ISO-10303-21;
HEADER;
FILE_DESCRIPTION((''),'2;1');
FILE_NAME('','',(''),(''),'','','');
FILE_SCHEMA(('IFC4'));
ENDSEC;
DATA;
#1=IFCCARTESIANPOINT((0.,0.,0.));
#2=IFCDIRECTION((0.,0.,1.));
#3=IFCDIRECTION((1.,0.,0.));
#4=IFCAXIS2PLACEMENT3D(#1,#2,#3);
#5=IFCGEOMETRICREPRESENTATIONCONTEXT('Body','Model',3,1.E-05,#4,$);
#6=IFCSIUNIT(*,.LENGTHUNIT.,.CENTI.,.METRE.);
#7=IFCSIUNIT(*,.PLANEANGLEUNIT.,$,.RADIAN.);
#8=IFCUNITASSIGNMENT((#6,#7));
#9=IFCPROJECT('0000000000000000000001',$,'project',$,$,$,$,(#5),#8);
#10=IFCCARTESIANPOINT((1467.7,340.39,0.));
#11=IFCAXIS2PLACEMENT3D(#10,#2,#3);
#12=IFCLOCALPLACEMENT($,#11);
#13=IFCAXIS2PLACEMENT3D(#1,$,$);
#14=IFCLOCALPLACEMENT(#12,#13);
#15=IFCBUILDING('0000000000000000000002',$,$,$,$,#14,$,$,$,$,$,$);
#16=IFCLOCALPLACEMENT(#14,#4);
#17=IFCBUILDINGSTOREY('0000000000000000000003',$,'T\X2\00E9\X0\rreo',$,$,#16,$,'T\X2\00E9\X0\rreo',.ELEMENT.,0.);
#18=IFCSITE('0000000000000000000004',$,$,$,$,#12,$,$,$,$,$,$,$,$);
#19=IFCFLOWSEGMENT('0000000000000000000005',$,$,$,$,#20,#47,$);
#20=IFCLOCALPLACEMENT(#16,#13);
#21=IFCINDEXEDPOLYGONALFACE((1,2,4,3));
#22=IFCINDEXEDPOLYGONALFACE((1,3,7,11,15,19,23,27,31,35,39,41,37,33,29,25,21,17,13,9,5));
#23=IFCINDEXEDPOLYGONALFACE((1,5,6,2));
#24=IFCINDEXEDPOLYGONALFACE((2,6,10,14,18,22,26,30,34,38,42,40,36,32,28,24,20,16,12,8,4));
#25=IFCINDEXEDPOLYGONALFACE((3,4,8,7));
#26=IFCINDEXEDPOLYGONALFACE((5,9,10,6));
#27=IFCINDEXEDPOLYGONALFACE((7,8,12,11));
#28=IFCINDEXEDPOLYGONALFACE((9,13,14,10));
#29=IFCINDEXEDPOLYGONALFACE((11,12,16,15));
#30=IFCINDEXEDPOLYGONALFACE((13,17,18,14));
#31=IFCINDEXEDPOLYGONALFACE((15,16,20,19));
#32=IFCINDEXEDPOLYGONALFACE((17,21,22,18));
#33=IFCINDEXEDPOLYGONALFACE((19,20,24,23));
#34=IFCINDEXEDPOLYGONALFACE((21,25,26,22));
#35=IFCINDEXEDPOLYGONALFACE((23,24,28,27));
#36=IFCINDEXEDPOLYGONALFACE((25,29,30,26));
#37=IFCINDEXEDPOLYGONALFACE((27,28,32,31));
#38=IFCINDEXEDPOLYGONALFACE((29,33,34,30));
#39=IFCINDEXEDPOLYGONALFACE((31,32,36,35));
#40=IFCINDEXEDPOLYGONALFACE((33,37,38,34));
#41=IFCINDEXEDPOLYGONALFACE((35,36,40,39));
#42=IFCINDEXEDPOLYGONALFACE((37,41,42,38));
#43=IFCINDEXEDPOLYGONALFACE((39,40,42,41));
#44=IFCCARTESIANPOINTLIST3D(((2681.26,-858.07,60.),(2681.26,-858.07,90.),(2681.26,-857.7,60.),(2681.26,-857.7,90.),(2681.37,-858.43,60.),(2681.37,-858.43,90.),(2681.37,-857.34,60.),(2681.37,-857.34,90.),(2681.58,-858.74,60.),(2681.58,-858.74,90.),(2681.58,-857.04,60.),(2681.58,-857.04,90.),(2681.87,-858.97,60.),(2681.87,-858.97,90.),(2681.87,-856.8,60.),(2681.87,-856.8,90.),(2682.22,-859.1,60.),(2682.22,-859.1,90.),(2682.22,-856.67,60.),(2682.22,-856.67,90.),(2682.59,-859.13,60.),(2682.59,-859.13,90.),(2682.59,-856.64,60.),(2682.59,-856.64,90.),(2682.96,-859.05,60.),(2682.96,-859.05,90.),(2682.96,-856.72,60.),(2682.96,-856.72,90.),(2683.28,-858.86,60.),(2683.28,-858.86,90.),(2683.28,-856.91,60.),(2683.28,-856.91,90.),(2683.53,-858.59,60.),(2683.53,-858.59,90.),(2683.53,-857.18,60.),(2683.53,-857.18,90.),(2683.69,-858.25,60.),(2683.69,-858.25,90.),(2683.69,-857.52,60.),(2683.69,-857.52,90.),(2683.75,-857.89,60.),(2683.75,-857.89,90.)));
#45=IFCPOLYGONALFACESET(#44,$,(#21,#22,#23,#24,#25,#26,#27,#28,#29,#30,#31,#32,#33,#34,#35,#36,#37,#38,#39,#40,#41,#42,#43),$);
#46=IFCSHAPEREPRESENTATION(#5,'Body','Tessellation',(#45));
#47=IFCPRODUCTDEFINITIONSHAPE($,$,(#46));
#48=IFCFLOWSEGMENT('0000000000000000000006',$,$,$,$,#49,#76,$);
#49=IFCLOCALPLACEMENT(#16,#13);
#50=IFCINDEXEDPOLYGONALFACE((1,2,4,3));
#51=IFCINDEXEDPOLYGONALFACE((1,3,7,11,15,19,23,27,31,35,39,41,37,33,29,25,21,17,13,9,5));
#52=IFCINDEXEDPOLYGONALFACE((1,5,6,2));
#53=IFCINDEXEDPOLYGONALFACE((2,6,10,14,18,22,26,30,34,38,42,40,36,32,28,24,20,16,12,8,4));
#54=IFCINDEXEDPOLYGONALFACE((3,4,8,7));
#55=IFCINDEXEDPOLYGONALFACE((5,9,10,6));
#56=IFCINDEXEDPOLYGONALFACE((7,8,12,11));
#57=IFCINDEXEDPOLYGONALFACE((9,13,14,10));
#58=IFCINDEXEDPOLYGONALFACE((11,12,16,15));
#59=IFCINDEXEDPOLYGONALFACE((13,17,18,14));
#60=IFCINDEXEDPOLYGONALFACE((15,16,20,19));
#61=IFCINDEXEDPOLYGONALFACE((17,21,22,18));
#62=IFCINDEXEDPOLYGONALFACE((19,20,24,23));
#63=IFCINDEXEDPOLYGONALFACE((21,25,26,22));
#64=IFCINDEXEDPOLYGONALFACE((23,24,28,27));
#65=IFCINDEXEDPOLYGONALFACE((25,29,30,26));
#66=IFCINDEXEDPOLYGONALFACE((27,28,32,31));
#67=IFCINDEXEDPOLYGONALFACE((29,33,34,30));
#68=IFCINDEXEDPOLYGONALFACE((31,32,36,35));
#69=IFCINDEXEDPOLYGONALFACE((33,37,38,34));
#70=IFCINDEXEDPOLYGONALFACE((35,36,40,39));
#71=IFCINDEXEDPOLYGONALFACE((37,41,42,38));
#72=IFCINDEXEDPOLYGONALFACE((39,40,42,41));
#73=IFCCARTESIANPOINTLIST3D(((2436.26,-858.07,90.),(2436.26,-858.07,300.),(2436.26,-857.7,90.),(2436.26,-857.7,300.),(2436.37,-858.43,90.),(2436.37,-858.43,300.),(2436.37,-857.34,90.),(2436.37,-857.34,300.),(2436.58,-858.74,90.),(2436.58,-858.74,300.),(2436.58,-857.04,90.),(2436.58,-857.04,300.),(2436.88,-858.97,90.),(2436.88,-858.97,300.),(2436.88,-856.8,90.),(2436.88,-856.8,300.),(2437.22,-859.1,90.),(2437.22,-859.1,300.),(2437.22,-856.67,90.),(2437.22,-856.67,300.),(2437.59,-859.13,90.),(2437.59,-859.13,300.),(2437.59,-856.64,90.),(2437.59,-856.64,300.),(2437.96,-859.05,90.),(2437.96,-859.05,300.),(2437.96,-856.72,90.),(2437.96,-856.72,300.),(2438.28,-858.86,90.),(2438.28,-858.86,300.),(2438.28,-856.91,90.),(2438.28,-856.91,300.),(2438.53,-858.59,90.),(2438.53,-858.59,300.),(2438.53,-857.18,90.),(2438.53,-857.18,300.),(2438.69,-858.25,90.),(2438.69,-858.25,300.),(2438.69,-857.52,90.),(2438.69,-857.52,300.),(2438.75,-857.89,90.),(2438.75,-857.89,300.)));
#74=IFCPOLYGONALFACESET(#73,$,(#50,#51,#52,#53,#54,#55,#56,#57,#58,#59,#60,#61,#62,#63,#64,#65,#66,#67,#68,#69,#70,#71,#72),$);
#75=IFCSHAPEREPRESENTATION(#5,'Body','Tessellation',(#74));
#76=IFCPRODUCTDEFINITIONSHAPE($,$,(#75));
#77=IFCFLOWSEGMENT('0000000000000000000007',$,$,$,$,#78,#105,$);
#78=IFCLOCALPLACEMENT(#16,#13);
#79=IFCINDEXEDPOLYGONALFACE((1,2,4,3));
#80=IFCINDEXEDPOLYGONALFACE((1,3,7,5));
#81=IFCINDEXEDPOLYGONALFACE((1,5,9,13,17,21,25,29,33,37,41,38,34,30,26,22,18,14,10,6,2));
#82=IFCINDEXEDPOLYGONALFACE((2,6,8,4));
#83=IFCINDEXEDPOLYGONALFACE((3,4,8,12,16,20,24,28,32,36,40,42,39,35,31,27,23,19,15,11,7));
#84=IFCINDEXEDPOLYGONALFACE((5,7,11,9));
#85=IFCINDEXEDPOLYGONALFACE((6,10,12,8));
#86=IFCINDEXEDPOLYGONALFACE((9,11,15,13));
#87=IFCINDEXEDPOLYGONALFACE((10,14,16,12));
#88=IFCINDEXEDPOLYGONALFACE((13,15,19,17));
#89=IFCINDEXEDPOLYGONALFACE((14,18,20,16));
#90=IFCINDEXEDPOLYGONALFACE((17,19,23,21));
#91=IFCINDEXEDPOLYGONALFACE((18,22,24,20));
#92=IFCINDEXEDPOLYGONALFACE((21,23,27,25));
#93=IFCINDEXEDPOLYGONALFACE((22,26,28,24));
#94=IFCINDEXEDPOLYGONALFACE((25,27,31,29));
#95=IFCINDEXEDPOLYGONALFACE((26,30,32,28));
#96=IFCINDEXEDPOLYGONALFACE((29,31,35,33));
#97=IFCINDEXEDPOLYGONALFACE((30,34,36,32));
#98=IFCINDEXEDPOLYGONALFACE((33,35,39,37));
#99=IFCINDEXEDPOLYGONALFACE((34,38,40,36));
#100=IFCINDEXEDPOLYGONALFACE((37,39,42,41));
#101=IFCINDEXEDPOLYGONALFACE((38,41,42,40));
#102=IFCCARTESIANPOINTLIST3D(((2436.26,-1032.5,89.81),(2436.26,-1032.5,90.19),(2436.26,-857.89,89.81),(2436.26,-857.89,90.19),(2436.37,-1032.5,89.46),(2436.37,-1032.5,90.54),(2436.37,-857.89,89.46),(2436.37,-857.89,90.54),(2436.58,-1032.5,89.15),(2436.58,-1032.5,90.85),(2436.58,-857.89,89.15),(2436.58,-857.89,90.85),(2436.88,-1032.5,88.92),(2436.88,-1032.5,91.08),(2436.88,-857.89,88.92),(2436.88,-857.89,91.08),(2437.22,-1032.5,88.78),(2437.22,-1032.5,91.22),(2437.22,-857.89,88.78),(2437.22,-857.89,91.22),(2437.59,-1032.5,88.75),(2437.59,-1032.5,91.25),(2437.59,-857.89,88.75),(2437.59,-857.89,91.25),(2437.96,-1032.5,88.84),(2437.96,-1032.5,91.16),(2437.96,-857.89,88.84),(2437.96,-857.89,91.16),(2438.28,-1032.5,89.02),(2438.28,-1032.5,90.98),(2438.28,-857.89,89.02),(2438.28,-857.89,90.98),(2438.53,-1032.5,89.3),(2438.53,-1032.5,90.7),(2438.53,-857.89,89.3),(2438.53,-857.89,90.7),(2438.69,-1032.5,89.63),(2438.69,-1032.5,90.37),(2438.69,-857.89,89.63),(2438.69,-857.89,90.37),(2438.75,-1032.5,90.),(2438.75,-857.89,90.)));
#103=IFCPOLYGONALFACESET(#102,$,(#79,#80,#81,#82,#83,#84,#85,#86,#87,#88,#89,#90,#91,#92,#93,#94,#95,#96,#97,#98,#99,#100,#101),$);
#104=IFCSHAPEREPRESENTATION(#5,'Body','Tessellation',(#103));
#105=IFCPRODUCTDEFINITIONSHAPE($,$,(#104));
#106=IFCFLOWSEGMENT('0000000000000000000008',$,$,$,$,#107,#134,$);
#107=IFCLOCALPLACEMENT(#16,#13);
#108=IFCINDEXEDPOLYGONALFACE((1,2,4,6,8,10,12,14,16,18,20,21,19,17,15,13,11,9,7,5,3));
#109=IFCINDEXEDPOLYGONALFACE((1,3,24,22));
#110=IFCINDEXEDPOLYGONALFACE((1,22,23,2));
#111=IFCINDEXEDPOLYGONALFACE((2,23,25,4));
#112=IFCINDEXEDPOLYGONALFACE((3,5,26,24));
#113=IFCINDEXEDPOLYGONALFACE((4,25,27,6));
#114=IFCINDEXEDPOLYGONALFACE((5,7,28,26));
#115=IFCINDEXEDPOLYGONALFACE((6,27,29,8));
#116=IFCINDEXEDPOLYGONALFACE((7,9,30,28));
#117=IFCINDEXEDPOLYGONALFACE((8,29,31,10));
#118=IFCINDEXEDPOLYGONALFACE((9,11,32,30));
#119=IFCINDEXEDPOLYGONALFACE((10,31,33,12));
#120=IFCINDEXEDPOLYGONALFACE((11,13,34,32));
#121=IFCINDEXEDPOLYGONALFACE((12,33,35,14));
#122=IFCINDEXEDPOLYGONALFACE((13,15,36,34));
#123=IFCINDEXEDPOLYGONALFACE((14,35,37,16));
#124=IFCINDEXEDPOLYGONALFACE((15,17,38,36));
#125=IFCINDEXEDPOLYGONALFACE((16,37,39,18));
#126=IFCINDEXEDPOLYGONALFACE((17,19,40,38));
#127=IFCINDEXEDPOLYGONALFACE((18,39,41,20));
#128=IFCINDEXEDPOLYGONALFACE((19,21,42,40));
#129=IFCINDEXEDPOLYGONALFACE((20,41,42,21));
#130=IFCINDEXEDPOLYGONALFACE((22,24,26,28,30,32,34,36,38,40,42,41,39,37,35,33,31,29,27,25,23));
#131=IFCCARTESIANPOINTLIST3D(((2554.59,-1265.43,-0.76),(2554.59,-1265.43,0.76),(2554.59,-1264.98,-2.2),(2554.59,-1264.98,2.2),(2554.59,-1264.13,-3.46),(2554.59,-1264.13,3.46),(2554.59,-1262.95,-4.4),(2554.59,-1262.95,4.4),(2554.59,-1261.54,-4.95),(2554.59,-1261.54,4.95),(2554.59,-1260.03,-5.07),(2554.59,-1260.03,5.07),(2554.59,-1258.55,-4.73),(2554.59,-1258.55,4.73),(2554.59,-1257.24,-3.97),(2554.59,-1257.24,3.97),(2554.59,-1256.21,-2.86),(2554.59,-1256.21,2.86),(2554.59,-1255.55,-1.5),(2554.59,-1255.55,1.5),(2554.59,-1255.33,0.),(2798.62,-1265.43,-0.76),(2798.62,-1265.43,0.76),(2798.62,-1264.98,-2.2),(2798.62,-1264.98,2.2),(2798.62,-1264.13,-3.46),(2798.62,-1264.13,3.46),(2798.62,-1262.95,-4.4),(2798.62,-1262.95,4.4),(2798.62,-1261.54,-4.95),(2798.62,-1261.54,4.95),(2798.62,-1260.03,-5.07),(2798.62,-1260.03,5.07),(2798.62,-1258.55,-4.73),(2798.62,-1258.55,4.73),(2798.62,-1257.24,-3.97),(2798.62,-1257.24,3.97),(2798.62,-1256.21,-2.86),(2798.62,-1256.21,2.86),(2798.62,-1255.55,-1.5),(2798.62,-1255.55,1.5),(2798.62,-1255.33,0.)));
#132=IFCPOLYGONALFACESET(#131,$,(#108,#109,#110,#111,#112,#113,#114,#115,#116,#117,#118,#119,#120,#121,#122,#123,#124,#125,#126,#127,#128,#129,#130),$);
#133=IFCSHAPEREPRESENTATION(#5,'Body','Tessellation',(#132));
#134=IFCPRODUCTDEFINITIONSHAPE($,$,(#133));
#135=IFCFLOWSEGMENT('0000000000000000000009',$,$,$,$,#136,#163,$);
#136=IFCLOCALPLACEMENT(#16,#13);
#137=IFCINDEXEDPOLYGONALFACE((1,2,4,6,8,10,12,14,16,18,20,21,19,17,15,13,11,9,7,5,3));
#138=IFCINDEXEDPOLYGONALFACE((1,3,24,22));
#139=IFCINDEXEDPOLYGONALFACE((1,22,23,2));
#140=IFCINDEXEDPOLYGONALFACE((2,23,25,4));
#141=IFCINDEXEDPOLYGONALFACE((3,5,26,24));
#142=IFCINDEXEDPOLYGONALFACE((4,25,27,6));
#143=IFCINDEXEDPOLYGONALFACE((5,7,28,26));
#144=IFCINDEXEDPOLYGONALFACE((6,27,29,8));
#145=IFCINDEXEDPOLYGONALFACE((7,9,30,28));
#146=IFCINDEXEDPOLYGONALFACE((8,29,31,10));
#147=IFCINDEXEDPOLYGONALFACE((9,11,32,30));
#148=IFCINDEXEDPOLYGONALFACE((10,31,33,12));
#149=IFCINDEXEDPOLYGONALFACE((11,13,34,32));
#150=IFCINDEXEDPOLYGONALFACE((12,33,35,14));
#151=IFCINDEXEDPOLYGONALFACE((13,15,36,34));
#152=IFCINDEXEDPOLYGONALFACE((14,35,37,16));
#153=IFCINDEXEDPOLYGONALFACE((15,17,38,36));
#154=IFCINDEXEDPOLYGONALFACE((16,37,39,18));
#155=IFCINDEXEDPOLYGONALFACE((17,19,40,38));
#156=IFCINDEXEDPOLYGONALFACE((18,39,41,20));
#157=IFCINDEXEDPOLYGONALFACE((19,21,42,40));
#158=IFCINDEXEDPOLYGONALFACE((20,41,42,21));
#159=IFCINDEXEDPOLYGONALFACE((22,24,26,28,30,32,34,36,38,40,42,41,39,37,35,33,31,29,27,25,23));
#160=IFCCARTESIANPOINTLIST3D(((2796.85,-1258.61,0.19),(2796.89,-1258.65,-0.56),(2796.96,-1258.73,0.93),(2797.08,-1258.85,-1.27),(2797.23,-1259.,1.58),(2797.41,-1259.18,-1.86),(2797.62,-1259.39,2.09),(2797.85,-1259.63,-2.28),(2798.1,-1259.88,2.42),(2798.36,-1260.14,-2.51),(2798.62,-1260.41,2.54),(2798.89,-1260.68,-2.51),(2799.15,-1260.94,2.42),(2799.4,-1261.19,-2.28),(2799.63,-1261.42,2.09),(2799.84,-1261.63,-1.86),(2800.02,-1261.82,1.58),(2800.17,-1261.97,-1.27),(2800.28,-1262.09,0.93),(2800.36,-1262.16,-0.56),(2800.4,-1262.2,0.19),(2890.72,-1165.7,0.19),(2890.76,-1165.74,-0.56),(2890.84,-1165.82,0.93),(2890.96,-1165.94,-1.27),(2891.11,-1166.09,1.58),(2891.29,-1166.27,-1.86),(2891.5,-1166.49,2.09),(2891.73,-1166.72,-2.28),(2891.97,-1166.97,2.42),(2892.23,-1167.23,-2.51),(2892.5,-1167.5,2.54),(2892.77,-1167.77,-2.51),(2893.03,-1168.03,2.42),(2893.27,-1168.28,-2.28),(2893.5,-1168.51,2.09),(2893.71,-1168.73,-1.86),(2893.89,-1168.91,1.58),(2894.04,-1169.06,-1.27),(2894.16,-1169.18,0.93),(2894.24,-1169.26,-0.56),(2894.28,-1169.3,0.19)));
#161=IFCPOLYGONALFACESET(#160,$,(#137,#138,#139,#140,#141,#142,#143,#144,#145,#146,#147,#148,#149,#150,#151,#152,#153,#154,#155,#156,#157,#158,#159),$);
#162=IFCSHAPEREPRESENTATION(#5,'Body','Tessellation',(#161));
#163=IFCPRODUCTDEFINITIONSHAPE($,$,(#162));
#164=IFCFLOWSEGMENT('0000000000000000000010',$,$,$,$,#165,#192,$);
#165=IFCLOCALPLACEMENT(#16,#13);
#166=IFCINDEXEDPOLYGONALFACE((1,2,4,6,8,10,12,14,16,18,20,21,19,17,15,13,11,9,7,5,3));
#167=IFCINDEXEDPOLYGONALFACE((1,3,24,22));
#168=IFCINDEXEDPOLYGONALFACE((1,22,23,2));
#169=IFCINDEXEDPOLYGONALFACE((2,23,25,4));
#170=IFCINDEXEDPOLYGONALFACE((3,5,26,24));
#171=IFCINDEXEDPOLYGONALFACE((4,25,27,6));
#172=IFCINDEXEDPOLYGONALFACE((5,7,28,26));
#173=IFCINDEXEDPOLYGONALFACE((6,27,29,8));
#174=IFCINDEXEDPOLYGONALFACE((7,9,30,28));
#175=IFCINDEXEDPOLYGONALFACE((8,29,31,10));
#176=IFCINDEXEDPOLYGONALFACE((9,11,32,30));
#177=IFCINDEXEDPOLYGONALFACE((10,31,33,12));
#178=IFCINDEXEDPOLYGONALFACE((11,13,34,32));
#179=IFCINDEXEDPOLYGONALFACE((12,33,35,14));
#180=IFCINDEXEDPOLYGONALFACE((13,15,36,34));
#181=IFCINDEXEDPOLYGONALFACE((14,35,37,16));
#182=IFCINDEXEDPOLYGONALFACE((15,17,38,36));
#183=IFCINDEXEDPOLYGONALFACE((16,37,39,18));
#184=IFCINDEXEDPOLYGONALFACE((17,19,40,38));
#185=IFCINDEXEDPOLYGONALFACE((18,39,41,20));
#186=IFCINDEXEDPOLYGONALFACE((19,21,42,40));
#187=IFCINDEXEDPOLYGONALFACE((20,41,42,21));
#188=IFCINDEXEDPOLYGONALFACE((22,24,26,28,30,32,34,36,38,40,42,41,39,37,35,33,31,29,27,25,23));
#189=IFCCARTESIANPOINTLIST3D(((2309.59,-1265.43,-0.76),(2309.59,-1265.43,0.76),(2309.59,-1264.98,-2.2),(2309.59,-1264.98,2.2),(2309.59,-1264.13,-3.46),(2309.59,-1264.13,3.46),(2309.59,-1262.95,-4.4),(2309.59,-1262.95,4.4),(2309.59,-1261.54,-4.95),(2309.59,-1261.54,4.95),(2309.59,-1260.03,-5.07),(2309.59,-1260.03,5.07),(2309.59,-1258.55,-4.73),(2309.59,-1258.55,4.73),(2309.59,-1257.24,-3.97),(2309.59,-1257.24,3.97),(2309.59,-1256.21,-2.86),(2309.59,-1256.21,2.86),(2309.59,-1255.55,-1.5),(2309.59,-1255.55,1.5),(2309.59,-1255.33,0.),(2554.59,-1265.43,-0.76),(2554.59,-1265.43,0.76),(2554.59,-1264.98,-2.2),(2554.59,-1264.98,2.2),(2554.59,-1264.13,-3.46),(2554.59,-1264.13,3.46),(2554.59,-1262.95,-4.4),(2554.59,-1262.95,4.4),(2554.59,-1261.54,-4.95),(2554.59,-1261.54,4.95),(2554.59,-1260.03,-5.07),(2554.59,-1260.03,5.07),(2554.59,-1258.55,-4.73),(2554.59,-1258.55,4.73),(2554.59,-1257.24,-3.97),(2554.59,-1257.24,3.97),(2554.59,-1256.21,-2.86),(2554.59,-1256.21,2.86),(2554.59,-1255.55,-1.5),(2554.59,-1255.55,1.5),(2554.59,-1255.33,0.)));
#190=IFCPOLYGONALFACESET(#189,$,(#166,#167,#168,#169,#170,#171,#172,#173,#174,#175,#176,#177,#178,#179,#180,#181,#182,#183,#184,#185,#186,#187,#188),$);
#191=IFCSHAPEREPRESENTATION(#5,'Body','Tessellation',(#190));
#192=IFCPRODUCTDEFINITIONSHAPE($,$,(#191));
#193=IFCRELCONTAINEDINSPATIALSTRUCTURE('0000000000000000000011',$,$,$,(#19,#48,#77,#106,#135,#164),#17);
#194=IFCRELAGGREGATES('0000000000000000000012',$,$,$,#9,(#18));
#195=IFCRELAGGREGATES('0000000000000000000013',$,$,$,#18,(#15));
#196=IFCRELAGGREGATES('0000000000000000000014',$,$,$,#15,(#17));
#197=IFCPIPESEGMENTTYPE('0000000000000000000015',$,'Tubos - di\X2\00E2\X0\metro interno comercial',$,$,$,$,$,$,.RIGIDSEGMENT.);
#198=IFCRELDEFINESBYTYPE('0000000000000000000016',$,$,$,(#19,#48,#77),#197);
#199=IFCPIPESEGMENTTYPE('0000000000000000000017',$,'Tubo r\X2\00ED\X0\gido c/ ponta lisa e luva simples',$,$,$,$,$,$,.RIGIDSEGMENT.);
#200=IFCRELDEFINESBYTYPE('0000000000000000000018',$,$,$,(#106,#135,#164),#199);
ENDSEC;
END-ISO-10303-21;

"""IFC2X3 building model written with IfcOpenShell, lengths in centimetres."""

from ifc_helpers import new_model, si_unit, frame, origin, origin_with_axes, origin_2d_with_axis, place, context, project, spatial, circle, extrude, type_object, element, save


model = new_model("IFC2X3")

# Units and contexts
model_context = context("Model", 3, precision=1e-05, world=origin_with_axes(), identifier="Body")
ifc_project = project(units=[si_unit("LENGTHUNIT", "METRE", prefix="CENTI"), si_unit("PLANEANGLEUNIT", "RADIAN")], contexts=[model_context])

# Site, building, storey
site_placement = place(None, frame((1467.7, 340.39, 0.0), z_axis=(0.0, 0.0, 1.0), x_axis=(1.0, 0.0, 0.0)))
site = spatial("IfcSite", under=ifc_project, at=site_placement)
building_placement = place(site_placement, origin())
building = spatial("IfcBuilding", under=site, at=building_placement)
storey_placement = place(building_placement, origin_with_axes())
storey = spatial("IfcBuildingStorey", under=building, at=storey_placement, Name="Térreo", LongName="Térreo", CompositionType="ELEMENT", Elevation=0.0)

# Flow segments
pipe_segment_type_1 = type_object("IfcPipeSegmentType", Name="Tubos - diâmetro interno comercial", PredefinedType="RIGIDSEGMENT")
for number, where, z_axis, x_axis in (
    (1, (2682.5, -857.89, 90.0), (0.0, 0.0, 1.0), (1.0, 0.0, 0.0)),
):
    element("IfcFlowSegment", number, at=place(storey_placement, frame(where, z_axis=z_axis, x_axis=x_axis)), inside=storey, type_object=pipe_segment_type_1, context=model_context, shape_type="SolidModel", body=[
        extrude(circle(Radius=1.25, at=origin_2d_with_axis()), frame((0.0, 0.0, 0.0), z_axis=(0.0, 0.0, -1.0), x_axis=(1.0, 0.0, 0.0)), (0.0, 0.0, 1.0), 30.0),
    ])
flow_segment_1_placement = place(storey_placement, frame((2437.5, -857.89, 300.0), z_axis=(0.0, 0.0, 1.0), x_axis=(1.0, 0.0, 0.0)))
element("IfcFlowSegment", 2, at=flow_segment_1_placement, inside=storey, type_object=pipe_segment_type_1, context=model_context, shape_type="SolidModel", body=[
    extrude(circle(Radius=1.25, at=origin_2d_with_axis()), frame((0.0, 0.0, 0.0), z_axis=(0.0, 0.0, -1.0), x_axis=(1.0, 0.0, 0.0)), (0.0, 0.0, 1.0), 210.0),
])
flow_segment_2_placement = place(storey_placement, frame((2437.5, -945.19, 91.25), z_axis=(0.0, 0.0, 1.0), x_axis=(1.0, 0.0, 0.0)))
element("IfcFlowSegment", 3, at=flow_segment_2_placement, inside=storey, type_object=pipe_segment_type_1, context=model_context, shape_type="SolidModel", body=[
    extrude(circle(Radius=1.25, at=origin_2d_with_axis()), frame((0.0, 87.31, -1.25), z_axis=(0.0, -1.0, 0.0), x_axis=(1.0, 0.0, 0.0)), (0.0, 0.0, 1.0), 174.61),
])
pipe_segment_type_2 = type_object("IfcPipeSegmentType", Name="Tubo rígido c/ ponta lisa e luva simples", PredefinedType="RIGIDSEGMENT")
flow_segment_3_placement = place(storey_placement, frame((2676.61, -1260.41, 5.08), z_axis=(0.0, 0.0, 1.0), x_axis=(1.0, 0.0, 0.0)))
element("IfcFlowSegment", 4, at=flow_segment_3_placement, inside=storey, type_object=pipe_segment_type_2, context=model_context, shape_type="SolidModel", body=[
    extrude(circle(Radius=5.08, at=origin_2d_with_axis()), frame((122.02, 0.0, -5.08), z_axis=(-1.0, 0.0, 0.0), x_axis=(0.0, 1.0, 0.0)), (0.0, 0.0, 1.0), 244.03),
])
flow_segment_4_placement = place(storey_placement, frame((2845.56, -1213.95, 2.54), z_axis=(0.0, 0.0, 1.0), x_axis=(1.0, 0.0, 0.0)))
element("IfcFlowSegment", 5, at=flow_segment_4_placement, inside=storey, type_object=pipe_segment_type_2, context=model_context, shape_type="SolidModel", body=[
    extrude(circle(Radius=2.54, at=origin_2d_with_axis()), frame((46.94, 46.45, -2.54), z_axis=(-0.71076, -0.703434, 0.0), x_axis=(0.0, 0.0, 1.0)), (0.0, 0.0, 1.0), 132.08),
])
flow_segment_5_placement = place(storey_placement, frame((2432.09, -1260.41, 5.08), z_axis=(0.0, 0.0, 1.0), x_axis=(1.0, 0.0, 0.0)))
element("IfcFlowSegment", 6, at=flow_segment_5_placement, inside=storey, type_object=pipe_segment_type_2, context=model_context, shape_type="SolidModel", body=[
    extrude(circle(Radius=5.08, at=origin_2d_with_axis()), frame((122.5, 0.0, -5.08), z_axis=(-1.0, 0.0, 0.0), x_axis=(0.0, 1.0, 0.0)), (0.0, 0.0, 1.0), 245.0),
])

save(model, "model.ifc")
